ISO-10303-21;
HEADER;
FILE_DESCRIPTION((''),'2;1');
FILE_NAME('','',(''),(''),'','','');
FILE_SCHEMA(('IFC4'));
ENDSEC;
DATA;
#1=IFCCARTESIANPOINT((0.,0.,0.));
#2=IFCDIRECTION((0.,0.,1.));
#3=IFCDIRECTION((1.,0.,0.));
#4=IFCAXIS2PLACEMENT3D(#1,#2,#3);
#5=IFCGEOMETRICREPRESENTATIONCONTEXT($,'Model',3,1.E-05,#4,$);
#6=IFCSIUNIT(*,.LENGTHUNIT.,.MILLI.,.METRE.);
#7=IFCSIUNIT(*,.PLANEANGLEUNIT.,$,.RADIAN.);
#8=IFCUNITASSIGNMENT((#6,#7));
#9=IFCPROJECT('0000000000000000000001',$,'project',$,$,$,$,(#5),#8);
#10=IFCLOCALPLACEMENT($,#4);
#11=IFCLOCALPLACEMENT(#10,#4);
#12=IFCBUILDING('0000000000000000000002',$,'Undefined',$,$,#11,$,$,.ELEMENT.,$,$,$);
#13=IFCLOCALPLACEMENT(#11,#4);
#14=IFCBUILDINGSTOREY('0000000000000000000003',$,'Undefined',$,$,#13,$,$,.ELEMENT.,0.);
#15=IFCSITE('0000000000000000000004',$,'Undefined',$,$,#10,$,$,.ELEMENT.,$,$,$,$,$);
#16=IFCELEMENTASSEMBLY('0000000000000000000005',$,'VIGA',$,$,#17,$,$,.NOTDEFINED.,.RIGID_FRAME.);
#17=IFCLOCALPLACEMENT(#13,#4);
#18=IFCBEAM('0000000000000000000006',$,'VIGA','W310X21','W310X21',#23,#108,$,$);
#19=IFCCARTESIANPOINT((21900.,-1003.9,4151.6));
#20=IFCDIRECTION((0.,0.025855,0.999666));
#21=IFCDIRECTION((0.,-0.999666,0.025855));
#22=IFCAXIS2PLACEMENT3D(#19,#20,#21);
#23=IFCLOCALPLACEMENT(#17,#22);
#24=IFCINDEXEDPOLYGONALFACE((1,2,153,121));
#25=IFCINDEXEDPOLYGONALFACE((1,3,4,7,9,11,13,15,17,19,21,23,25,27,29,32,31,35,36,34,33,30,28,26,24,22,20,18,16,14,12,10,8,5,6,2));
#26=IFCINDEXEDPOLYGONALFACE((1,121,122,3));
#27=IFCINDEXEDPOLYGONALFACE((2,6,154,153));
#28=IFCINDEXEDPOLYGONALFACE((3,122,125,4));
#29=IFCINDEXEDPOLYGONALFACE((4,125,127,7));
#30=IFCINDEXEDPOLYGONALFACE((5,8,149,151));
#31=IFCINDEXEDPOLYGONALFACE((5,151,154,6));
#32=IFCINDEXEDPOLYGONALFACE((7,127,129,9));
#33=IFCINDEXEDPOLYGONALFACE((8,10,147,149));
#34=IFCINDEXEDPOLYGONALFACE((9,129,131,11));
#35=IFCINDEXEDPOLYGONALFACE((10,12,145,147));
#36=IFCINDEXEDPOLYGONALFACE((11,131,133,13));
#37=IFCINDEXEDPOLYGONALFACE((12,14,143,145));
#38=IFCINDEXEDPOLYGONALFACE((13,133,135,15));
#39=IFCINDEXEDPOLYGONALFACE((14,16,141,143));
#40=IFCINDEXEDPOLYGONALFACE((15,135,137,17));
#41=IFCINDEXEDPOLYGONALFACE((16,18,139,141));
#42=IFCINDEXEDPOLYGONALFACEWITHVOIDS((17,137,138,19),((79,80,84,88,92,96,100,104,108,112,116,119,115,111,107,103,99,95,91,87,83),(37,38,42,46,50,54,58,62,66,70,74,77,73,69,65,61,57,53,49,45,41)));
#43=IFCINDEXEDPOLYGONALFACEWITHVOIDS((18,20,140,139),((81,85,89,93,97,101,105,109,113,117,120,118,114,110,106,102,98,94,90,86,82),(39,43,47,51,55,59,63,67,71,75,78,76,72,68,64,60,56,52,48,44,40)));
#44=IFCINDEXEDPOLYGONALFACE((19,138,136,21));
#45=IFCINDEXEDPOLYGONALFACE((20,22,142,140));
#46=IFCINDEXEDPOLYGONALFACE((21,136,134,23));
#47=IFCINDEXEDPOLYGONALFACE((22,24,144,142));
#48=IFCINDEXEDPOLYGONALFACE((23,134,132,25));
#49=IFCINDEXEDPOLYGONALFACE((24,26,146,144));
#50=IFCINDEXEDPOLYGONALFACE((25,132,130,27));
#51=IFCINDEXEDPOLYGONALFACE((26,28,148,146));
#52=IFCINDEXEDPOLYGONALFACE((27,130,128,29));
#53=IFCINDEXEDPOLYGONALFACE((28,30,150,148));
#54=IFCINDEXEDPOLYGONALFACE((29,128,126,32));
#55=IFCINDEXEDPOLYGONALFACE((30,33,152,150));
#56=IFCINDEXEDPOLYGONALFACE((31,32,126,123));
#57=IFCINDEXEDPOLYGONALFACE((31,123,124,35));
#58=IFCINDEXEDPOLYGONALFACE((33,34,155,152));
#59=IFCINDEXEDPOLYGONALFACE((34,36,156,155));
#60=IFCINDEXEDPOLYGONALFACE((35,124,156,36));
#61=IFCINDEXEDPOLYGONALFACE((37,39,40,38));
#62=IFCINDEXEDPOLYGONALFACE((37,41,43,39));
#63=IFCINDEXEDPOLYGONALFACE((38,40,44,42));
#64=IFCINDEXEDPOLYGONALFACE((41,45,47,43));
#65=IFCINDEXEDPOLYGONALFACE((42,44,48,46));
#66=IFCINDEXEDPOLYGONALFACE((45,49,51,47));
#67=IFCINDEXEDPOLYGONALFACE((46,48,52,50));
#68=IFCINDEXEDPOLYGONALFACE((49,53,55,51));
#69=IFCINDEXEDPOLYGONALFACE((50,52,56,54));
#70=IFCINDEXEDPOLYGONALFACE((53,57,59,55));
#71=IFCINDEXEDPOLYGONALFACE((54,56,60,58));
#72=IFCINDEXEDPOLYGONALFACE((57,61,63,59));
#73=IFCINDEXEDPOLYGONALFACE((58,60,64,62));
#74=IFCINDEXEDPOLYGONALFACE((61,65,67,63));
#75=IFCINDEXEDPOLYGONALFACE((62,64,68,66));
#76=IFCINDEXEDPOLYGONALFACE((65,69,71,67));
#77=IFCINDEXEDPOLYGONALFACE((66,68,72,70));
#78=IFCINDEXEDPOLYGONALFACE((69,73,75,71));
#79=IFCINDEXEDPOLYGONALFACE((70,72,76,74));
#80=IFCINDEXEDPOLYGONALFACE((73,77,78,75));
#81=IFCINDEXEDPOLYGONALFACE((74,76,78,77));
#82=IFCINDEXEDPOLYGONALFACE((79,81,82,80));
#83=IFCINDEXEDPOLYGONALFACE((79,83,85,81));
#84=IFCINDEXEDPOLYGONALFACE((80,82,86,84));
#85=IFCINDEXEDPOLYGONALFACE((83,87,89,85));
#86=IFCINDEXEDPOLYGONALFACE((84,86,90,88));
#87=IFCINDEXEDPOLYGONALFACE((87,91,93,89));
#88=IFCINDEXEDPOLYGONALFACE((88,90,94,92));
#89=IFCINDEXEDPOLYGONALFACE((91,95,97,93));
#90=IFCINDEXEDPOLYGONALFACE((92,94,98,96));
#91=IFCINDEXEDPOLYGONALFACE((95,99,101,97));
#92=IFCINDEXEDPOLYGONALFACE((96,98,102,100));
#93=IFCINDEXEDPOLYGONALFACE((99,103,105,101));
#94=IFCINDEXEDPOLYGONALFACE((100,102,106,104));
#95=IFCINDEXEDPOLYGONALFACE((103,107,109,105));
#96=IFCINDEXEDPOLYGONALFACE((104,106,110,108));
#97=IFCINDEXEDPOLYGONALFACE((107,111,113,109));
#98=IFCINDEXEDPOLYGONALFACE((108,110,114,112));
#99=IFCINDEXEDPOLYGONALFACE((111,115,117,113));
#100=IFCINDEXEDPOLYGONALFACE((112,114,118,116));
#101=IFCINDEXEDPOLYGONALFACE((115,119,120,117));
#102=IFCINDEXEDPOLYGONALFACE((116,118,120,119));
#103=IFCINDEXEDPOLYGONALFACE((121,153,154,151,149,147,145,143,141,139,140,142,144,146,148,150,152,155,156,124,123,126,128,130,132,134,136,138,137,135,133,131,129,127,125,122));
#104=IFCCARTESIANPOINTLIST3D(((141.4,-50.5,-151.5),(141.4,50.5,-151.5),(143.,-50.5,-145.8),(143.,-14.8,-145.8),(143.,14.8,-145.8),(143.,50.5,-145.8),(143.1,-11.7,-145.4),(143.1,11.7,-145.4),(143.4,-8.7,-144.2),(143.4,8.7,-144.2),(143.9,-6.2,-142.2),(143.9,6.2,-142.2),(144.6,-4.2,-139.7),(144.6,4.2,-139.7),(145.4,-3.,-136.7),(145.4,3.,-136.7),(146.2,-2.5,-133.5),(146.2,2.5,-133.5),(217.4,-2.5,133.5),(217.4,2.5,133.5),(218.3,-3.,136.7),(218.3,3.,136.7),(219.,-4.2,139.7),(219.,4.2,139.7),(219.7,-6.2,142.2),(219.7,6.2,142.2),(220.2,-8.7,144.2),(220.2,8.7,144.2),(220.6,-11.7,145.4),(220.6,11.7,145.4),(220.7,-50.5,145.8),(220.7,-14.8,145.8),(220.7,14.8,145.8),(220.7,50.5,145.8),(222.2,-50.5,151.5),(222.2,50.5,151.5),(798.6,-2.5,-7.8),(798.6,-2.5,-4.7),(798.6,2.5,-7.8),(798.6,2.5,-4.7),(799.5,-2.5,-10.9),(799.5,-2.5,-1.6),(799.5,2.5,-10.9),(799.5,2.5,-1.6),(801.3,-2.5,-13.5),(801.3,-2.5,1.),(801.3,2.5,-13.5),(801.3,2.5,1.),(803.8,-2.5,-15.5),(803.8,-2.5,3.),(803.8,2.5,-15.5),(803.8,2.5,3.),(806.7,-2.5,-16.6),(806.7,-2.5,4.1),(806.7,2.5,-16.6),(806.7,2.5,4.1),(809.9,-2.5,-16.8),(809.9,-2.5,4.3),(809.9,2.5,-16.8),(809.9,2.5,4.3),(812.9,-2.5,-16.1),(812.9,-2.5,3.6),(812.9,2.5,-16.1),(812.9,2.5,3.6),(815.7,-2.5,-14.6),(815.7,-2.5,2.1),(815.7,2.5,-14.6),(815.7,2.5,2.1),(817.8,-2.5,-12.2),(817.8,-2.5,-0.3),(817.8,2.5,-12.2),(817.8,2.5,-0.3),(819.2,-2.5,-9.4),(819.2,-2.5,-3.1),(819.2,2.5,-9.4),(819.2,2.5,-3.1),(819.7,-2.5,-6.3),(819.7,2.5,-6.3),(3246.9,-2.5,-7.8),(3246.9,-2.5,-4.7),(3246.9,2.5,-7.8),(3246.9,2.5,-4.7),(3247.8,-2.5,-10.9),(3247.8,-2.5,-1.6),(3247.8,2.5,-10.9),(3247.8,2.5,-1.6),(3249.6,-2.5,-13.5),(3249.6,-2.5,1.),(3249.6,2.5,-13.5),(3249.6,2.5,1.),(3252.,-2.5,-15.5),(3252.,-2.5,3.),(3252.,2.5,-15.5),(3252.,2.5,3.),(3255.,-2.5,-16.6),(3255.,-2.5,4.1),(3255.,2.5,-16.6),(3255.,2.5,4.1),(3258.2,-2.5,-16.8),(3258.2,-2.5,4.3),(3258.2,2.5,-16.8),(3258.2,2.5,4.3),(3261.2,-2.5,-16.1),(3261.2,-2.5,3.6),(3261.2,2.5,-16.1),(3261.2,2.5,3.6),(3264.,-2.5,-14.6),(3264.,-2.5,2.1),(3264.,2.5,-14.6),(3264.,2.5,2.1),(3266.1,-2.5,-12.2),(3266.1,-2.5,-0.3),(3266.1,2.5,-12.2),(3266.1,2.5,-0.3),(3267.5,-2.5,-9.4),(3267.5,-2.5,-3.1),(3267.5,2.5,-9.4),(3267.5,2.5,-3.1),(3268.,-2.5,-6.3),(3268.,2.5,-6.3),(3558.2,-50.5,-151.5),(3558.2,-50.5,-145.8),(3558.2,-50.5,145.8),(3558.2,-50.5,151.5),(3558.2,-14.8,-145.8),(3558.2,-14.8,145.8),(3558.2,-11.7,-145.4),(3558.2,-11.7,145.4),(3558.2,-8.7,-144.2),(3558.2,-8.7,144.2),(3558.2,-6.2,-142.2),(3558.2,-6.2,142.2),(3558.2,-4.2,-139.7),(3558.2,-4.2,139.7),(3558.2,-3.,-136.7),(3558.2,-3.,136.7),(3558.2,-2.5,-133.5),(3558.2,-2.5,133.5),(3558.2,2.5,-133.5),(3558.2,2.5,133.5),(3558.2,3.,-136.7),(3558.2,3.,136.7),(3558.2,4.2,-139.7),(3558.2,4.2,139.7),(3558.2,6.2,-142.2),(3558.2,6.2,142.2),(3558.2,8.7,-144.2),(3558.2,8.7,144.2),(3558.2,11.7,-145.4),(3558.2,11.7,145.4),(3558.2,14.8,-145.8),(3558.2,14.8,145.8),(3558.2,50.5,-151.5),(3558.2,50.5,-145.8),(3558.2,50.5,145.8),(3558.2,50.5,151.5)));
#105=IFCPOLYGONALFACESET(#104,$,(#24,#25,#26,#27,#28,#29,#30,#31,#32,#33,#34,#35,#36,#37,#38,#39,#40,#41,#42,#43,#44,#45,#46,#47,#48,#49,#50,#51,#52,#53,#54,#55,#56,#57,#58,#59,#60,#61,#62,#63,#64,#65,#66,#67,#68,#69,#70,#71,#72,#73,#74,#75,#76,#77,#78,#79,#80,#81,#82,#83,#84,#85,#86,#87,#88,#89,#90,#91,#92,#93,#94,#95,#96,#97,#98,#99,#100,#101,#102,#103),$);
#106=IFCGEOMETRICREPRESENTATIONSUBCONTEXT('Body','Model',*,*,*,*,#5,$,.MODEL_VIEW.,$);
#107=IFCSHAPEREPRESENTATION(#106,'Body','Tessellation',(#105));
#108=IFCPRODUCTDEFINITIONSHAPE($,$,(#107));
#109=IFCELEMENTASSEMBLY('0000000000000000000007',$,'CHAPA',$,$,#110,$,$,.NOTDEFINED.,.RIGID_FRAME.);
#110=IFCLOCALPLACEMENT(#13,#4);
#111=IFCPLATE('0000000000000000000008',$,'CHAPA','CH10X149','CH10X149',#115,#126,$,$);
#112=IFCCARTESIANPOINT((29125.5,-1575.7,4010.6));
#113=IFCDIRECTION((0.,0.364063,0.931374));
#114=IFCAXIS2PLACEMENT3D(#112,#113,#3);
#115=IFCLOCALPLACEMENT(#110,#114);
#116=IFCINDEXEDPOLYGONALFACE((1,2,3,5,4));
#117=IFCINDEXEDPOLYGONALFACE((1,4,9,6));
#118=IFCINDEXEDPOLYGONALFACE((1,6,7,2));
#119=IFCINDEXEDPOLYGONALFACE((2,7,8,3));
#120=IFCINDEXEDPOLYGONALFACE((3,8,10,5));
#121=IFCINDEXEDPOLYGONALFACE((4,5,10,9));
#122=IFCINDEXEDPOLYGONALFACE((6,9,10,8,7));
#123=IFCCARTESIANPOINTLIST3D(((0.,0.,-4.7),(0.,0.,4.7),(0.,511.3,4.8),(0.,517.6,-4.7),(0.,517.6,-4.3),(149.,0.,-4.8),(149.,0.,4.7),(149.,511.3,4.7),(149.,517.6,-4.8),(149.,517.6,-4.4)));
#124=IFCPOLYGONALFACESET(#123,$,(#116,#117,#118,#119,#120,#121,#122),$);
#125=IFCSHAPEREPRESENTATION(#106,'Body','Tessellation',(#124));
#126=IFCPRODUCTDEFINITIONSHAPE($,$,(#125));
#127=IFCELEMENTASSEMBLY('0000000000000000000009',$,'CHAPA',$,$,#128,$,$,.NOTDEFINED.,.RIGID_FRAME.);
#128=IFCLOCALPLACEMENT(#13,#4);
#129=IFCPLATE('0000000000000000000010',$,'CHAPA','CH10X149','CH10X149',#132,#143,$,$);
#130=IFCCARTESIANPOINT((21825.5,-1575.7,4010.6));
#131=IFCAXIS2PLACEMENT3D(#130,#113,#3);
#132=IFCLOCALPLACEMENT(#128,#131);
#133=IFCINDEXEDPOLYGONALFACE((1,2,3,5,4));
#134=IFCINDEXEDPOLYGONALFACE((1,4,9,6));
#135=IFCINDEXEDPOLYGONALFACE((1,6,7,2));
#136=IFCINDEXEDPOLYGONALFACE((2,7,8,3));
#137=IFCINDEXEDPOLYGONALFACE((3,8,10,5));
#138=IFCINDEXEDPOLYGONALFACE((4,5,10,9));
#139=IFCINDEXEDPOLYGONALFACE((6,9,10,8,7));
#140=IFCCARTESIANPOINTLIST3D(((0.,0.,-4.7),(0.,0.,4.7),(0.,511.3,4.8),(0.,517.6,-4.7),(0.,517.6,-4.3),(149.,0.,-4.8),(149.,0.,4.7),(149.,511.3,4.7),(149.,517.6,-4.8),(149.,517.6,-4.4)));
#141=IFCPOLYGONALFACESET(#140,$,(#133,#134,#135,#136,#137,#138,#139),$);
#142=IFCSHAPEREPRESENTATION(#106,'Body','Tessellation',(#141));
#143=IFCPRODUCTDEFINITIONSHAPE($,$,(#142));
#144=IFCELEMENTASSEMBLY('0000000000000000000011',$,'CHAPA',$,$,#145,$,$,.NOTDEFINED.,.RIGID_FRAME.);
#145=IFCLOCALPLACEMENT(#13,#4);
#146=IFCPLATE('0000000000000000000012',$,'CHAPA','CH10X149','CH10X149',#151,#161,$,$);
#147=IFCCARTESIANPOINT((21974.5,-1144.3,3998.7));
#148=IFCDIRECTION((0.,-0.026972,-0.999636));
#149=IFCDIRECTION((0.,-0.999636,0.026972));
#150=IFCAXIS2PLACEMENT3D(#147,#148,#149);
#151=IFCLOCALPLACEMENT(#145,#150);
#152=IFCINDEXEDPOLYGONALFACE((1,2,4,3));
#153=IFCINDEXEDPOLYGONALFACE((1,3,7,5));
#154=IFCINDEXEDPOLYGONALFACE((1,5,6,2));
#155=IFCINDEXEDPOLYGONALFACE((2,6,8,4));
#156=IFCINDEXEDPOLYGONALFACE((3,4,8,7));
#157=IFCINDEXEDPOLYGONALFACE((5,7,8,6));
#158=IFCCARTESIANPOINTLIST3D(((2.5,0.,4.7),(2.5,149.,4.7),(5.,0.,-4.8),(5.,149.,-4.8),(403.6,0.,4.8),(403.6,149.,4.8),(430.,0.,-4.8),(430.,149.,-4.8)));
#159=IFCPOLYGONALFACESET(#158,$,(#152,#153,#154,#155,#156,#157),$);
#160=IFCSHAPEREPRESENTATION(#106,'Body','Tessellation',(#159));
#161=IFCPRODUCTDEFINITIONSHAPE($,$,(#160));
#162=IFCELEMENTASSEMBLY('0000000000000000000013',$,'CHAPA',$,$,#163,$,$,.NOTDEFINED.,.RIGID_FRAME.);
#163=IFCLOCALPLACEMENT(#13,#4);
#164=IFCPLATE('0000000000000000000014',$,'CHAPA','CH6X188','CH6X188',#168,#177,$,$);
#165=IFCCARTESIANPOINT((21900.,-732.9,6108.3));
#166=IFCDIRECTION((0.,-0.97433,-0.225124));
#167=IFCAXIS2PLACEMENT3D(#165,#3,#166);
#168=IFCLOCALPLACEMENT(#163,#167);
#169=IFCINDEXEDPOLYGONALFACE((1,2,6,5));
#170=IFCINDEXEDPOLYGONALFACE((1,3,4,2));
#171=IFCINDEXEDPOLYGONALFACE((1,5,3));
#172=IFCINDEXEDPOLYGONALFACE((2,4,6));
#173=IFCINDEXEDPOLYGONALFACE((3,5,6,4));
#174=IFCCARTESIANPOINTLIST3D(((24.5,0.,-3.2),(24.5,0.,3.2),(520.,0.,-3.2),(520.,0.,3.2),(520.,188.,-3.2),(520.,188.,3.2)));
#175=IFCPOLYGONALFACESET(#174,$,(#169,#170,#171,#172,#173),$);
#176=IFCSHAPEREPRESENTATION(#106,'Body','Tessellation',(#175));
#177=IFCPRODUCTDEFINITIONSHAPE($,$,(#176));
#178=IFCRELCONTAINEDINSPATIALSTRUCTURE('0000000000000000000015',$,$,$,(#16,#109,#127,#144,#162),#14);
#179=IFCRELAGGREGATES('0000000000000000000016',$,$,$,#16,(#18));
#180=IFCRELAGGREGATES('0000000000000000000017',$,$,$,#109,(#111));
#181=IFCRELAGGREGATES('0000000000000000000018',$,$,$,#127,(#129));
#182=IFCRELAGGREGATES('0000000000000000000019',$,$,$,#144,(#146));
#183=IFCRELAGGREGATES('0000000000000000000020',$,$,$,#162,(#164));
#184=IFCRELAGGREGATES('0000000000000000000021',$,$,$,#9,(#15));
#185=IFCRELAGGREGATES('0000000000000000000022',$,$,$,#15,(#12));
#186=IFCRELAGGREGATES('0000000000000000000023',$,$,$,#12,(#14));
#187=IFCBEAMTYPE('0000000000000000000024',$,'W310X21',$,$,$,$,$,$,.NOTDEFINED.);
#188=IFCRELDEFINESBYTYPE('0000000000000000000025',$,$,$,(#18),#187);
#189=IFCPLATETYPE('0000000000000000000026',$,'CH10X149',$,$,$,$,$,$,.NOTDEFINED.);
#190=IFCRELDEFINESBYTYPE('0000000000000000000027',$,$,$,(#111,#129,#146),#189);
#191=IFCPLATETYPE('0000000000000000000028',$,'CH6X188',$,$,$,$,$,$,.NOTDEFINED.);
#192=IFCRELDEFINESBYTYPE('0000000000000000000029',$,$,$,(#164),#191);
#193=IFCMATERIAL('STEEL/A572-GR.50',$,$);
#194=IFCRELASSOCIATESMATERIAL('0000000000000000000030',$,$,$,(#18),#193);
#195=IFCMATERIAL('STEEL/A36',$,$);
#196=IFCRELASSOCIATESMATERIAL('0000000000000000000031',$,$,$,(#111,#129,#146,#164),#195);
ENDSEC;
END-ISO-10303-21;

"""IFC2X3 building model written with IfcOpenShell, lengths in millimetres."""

from ifc_helpers import new_model, si_unit, frame, origin_with_axes, origin_2d_with_axis, place, context, subcontext, project, spatial, polyline, circle, i_section, outline, extrude, boolean, clip, halfspace, material, type_object, element, aggregate, save


model = new_model("IFC2X3")

# Units and contexts
model_context = context("Model", 3, precision=1e-05, world=origin_with_axes())
body_context = subcontext(model_context, "Body", "Model", "MODEL_VIEW")
ifc_project = project(units=[si_unit("LENGTHUNIT", "METRE", prefix="MILLI"), si_unit("PLANEANGLEUNIT", "RADIAN")], contexts=[model_context])

# Site, building, storey
site_placement = place(None, origin_with_axes())
site = spatial("IfcSite", under=ifc_project, at=site_placement, Name="Undefined", CompositionType="ELEMENT")
building_placement = place(site_placement, origin_with_axes())
building = spatial("IfcBuilding", under=site, at=building_placement, Name="Undefined", CompositionType="ELEMENT")
storey_placement = place(building_placement, origin_with_axes())
storey = spatial("IfcBuildingStorey", under=building, at=storey_placement, Name="Undefined", CompositionType="ELEMENT", Elevation=0.0)

# Element assembly, beam
ifc_material_1 = material(Name="STEEL/A572-GR.50")
assembly_1_placement = place(storey_placement, origin_with_axes())
assembly_1 = element("IfcElementAssembly", 1, at=assembly_1_placement, inside=storey, Name="VIGA", AssemblyPlace="NOTDEFINED", PredefinedType="RIGID_FRAME")
beam_type_1 = type_object("IfcBeamType", Name="W310X21", PredefinedType="NOTDEFINED")
beam_1_placement = place(assembly_1_placement, frame((21900.0, -1003.9, 4151.6), z_axis=(0.0, 0.025855, 0.999666), x_axis=(0.0, -0.999666, 0.025855)))
beam_1 = element("IfcBeam", 2, at=beam_1_placement, type_object=beam_type_1, material=ifc_material_1, Name="VIGA", Description="W310X21", ObjectType="W310X21", context=body_context, shape_type="CSG", body=[
    boolean("DIFFERENCE", boolean("DIFFERENCE", boolean("DIFFERENCE", extrude(i_section(OverallWidth=101.0, OverallDepth=303.0, WebThickness=5.1, FlangeThickness=5.7, FilletRadius=12.3, at=origin_2d_with_axis()), frame((3558.2, 0.0, 0.0), z_axis=(-1.0, 0.0, 0.0), x_axis=(0.0, -1.0, 0.0)), (0.0, 0.0, 1.0), 3558.2), extrude(circle(Radius=10.6, at=origin_2d_with_axis()), frame((809.1, -100.0, -6.3), z_axis=(0.0, 1.0, 0.0), x_axis=(1.0, 0.0, 0.0)), (0.0, 0.0, 1.0), 200.0)), extrude(circle(Radius=10.6, at=origin_2d_with_axis()), frame((3257.4, -100.0, -6.3), z_axis=(0.0, 1.0, 0.0), x_axis=(1.0, 0.0, 0.0)), (0.0, 0.0, 1.0), 200.0)), halfspace(frame((141.4, 50.5, -151.7), z_axis=(-0.966259, 0.0, 0.257573), x_axis=(0.257573, 0.0, 0.966259)), False)),
])
aggregate(assembly_1, [beam_1])

# Shared definitions
ifc_material_2 = material(Name="STEEL/A36")

# Element assemblies, plates
assembly_2_placement = place(storey_placement, origin_with_axes())
assembly_2 = element("IfcElementAssembly", 3, at=assembly_2_placement, inside=storey, Name="CHAPA", AssemblyPlace="NOTDEFINED", PredefinedType="RIGID_FRAME")
plate_type_1 = type_object("IfcPlateType", Name="CH10X149", PredefinedType="NOTDEFINED")
plate_1_placement = place(assembly_2_placement, frame((29125.5, -1575.7, 4010.6), z_axis=(0.0, 0.364063, 0.931374), x_axis=(1.0, 0.0, 0.0)))
plate_1 = element("IfcPlate", 4, at=plate_1_placement, type_object=plate_type_1, material=ifc_material_2, Name="CHAPA", Description="CH10X149", ObjectType="CH10X149", context=body_context, shape_type="Clipping", body=[
    clip(extrude(outline(polyline([(0.0, 0.0), (149.0, 0.0), (149.0, 517.6), (0.0, 517.6), (0.0, 0.0)])), frame((0.0, 0.0, -4.8), z_axis=(0.0, 0.0, 1.0), x_axis=(1.0, 0.0, 0.0)), (0.0, 0.0, 1.0), 9.5), halfspace(frame((149.0, 517.9, -4.7), z_axis=(0.0, 0.821204, 0.570634), x_axis=(0.0, -0.570634, 0.821204)), False)),
])
aggregate(assembly_2, [plate_1])
assembly_3_placement = place(storey_placement, origin_with_axes())
assembly_3 = element("IfcElementAssembly", 5, at=assembly_3_placement, inside=storey, Name="CHAPA", AssemblyPlace="NOTDEFINED", PredefinedType="RIGID_FRAME")
plate_2_placement = place(assembly_3_placement, frame((21825.5, -1575.7, 4010.6), z_axis=(0.0, 0.364063, 0.931374), x_axis=(1.0, 0.0, 0.0)))
plate_2 = element("IfcPlate", 6, at=plate_2_placement, type_object=plate_type_1, material=ifc_material_2, Name="CHAPA", Description="CH10X149", ObjectType="CH10X149", context=body_context, shape_type="Clipping", body=[
    clip(extrude(outline(polyline([(0.0, 0.0), (149.0, 0.0), (149.0, 517.6), (0.0, 517.6), (0.0, 0.0)])), frame((0.0, 0.0, -4.8), z_axis=(0.0, 0.0, 1.0), x_axis=(1.0, 0.0, 0.0)), (0.0, 0.0, 1.0), 9.5), halfspace(frame((149.0, 517.9, -4.7), z_axis=(0.0, 0.821204, 0.570634), x_axis=(0.0, -0.570634, 0.821204)), False)),
])
aggregate(assembly_3, [plate_2])
assembly_4_placement = place(storey_placement, origin_with_axes())
assembly_4 = element("IfcElementAssembly", 7, at=assembly_4_placement, inside=storey, Name="CHAPA", AssemblyPlace="NOTDEFINED", PredefinedType="RIGID_FRAME")
plate_3_placement = place(assembly_4_placement, frame((21974.5, -1144.3, 3998.7), z_axis=(0.0, -0.026972, -0.999636), x_axis=(0.0, -0.999636, 0.026972)))
plate_3 = element("IfcPlate", 8, at=plate_3_placement, type_object=plate_type_1, material=ifc_material_2, Name="CHAPA", Description="CH10X149", ObjectType="CH10X149", context=body_context, shape_type="Clipping", body=[
    clip(clip(extrude(outline(polyline([(0.0, 0.0), (430.0, 0.0), (430.0, 149.0), (0.0, 149.0), (0.0, 0.0)])), frame((0.0, 0.0, -4.8), z_axis=(0.0, 0.0, 1.0), x_axis=(1.0, 0.0, 0.0)), (0.0, 0.0, 1.0), 9.5), halfspace(frame((403.6, -500.0, 4.7), z_axis=(0.33881, 0.0, 0.940855), x_axis=(0.0, 1.0, 0.0)), False)), halfspace(frame((5.0, -500.0, -4.8), z_axis=(-0.965989, 0.0, -0.258583), x_axis=(0.0, 1.0, 0.0)), False)),
])
aggregate(assembly_4, [plate_3])
assembly_5_placement = place(storey_placement, origin_with_axes())
assembly_5 = element("IfcElementAssembly", 9, at=assembly_5_placement, inside=storey, Name="CHAPA", AssemblyPlace="NOTDEFINED", PredefinedType="RIGID_FRAME")
plate_type_2 = type_object("IfcPlateType", Name="CH6X188", PredefinedType="NOTDEFINED")
plate_4_placement = place(assembly_5_placement, frame((21900.0, -732.9, 6108.3), z_axis=(1.0, 0.0, 0.0), x_axis=(0.0, -0.97433, -0.225124)))
plate_4 = element("IfcPlate", 10, at=plate_4_placement, type_object=plate_type_2, material=ifc_material_2, Name="CHAPA", Description="CH6X188", ObjectType="CH6X188", context=body_context, shape_type="Clipping", body=[
    clip(extrude(outline(polyline([(0.0, 0.0), (520.0, 0.0), (520.0, 191.6), (0.0, 0.0)])), frame((0.0, 0.0, -3.1), z_axis=(0.0, 0.0, 1.0), x_axis=(1.0, 0.0, 0.0)), (0.0, 0.0, 1.0), 6.3), halfspace(frame((1342.2, 500.0, 3.2), z_axis=(-0.354778, 0.934951, 0.0), x_axis=(-0.934951, -0.354778, 0.0)), False)),
])
aggregate(assembly_5, [plate_4])

save(model, "model.ifc")
